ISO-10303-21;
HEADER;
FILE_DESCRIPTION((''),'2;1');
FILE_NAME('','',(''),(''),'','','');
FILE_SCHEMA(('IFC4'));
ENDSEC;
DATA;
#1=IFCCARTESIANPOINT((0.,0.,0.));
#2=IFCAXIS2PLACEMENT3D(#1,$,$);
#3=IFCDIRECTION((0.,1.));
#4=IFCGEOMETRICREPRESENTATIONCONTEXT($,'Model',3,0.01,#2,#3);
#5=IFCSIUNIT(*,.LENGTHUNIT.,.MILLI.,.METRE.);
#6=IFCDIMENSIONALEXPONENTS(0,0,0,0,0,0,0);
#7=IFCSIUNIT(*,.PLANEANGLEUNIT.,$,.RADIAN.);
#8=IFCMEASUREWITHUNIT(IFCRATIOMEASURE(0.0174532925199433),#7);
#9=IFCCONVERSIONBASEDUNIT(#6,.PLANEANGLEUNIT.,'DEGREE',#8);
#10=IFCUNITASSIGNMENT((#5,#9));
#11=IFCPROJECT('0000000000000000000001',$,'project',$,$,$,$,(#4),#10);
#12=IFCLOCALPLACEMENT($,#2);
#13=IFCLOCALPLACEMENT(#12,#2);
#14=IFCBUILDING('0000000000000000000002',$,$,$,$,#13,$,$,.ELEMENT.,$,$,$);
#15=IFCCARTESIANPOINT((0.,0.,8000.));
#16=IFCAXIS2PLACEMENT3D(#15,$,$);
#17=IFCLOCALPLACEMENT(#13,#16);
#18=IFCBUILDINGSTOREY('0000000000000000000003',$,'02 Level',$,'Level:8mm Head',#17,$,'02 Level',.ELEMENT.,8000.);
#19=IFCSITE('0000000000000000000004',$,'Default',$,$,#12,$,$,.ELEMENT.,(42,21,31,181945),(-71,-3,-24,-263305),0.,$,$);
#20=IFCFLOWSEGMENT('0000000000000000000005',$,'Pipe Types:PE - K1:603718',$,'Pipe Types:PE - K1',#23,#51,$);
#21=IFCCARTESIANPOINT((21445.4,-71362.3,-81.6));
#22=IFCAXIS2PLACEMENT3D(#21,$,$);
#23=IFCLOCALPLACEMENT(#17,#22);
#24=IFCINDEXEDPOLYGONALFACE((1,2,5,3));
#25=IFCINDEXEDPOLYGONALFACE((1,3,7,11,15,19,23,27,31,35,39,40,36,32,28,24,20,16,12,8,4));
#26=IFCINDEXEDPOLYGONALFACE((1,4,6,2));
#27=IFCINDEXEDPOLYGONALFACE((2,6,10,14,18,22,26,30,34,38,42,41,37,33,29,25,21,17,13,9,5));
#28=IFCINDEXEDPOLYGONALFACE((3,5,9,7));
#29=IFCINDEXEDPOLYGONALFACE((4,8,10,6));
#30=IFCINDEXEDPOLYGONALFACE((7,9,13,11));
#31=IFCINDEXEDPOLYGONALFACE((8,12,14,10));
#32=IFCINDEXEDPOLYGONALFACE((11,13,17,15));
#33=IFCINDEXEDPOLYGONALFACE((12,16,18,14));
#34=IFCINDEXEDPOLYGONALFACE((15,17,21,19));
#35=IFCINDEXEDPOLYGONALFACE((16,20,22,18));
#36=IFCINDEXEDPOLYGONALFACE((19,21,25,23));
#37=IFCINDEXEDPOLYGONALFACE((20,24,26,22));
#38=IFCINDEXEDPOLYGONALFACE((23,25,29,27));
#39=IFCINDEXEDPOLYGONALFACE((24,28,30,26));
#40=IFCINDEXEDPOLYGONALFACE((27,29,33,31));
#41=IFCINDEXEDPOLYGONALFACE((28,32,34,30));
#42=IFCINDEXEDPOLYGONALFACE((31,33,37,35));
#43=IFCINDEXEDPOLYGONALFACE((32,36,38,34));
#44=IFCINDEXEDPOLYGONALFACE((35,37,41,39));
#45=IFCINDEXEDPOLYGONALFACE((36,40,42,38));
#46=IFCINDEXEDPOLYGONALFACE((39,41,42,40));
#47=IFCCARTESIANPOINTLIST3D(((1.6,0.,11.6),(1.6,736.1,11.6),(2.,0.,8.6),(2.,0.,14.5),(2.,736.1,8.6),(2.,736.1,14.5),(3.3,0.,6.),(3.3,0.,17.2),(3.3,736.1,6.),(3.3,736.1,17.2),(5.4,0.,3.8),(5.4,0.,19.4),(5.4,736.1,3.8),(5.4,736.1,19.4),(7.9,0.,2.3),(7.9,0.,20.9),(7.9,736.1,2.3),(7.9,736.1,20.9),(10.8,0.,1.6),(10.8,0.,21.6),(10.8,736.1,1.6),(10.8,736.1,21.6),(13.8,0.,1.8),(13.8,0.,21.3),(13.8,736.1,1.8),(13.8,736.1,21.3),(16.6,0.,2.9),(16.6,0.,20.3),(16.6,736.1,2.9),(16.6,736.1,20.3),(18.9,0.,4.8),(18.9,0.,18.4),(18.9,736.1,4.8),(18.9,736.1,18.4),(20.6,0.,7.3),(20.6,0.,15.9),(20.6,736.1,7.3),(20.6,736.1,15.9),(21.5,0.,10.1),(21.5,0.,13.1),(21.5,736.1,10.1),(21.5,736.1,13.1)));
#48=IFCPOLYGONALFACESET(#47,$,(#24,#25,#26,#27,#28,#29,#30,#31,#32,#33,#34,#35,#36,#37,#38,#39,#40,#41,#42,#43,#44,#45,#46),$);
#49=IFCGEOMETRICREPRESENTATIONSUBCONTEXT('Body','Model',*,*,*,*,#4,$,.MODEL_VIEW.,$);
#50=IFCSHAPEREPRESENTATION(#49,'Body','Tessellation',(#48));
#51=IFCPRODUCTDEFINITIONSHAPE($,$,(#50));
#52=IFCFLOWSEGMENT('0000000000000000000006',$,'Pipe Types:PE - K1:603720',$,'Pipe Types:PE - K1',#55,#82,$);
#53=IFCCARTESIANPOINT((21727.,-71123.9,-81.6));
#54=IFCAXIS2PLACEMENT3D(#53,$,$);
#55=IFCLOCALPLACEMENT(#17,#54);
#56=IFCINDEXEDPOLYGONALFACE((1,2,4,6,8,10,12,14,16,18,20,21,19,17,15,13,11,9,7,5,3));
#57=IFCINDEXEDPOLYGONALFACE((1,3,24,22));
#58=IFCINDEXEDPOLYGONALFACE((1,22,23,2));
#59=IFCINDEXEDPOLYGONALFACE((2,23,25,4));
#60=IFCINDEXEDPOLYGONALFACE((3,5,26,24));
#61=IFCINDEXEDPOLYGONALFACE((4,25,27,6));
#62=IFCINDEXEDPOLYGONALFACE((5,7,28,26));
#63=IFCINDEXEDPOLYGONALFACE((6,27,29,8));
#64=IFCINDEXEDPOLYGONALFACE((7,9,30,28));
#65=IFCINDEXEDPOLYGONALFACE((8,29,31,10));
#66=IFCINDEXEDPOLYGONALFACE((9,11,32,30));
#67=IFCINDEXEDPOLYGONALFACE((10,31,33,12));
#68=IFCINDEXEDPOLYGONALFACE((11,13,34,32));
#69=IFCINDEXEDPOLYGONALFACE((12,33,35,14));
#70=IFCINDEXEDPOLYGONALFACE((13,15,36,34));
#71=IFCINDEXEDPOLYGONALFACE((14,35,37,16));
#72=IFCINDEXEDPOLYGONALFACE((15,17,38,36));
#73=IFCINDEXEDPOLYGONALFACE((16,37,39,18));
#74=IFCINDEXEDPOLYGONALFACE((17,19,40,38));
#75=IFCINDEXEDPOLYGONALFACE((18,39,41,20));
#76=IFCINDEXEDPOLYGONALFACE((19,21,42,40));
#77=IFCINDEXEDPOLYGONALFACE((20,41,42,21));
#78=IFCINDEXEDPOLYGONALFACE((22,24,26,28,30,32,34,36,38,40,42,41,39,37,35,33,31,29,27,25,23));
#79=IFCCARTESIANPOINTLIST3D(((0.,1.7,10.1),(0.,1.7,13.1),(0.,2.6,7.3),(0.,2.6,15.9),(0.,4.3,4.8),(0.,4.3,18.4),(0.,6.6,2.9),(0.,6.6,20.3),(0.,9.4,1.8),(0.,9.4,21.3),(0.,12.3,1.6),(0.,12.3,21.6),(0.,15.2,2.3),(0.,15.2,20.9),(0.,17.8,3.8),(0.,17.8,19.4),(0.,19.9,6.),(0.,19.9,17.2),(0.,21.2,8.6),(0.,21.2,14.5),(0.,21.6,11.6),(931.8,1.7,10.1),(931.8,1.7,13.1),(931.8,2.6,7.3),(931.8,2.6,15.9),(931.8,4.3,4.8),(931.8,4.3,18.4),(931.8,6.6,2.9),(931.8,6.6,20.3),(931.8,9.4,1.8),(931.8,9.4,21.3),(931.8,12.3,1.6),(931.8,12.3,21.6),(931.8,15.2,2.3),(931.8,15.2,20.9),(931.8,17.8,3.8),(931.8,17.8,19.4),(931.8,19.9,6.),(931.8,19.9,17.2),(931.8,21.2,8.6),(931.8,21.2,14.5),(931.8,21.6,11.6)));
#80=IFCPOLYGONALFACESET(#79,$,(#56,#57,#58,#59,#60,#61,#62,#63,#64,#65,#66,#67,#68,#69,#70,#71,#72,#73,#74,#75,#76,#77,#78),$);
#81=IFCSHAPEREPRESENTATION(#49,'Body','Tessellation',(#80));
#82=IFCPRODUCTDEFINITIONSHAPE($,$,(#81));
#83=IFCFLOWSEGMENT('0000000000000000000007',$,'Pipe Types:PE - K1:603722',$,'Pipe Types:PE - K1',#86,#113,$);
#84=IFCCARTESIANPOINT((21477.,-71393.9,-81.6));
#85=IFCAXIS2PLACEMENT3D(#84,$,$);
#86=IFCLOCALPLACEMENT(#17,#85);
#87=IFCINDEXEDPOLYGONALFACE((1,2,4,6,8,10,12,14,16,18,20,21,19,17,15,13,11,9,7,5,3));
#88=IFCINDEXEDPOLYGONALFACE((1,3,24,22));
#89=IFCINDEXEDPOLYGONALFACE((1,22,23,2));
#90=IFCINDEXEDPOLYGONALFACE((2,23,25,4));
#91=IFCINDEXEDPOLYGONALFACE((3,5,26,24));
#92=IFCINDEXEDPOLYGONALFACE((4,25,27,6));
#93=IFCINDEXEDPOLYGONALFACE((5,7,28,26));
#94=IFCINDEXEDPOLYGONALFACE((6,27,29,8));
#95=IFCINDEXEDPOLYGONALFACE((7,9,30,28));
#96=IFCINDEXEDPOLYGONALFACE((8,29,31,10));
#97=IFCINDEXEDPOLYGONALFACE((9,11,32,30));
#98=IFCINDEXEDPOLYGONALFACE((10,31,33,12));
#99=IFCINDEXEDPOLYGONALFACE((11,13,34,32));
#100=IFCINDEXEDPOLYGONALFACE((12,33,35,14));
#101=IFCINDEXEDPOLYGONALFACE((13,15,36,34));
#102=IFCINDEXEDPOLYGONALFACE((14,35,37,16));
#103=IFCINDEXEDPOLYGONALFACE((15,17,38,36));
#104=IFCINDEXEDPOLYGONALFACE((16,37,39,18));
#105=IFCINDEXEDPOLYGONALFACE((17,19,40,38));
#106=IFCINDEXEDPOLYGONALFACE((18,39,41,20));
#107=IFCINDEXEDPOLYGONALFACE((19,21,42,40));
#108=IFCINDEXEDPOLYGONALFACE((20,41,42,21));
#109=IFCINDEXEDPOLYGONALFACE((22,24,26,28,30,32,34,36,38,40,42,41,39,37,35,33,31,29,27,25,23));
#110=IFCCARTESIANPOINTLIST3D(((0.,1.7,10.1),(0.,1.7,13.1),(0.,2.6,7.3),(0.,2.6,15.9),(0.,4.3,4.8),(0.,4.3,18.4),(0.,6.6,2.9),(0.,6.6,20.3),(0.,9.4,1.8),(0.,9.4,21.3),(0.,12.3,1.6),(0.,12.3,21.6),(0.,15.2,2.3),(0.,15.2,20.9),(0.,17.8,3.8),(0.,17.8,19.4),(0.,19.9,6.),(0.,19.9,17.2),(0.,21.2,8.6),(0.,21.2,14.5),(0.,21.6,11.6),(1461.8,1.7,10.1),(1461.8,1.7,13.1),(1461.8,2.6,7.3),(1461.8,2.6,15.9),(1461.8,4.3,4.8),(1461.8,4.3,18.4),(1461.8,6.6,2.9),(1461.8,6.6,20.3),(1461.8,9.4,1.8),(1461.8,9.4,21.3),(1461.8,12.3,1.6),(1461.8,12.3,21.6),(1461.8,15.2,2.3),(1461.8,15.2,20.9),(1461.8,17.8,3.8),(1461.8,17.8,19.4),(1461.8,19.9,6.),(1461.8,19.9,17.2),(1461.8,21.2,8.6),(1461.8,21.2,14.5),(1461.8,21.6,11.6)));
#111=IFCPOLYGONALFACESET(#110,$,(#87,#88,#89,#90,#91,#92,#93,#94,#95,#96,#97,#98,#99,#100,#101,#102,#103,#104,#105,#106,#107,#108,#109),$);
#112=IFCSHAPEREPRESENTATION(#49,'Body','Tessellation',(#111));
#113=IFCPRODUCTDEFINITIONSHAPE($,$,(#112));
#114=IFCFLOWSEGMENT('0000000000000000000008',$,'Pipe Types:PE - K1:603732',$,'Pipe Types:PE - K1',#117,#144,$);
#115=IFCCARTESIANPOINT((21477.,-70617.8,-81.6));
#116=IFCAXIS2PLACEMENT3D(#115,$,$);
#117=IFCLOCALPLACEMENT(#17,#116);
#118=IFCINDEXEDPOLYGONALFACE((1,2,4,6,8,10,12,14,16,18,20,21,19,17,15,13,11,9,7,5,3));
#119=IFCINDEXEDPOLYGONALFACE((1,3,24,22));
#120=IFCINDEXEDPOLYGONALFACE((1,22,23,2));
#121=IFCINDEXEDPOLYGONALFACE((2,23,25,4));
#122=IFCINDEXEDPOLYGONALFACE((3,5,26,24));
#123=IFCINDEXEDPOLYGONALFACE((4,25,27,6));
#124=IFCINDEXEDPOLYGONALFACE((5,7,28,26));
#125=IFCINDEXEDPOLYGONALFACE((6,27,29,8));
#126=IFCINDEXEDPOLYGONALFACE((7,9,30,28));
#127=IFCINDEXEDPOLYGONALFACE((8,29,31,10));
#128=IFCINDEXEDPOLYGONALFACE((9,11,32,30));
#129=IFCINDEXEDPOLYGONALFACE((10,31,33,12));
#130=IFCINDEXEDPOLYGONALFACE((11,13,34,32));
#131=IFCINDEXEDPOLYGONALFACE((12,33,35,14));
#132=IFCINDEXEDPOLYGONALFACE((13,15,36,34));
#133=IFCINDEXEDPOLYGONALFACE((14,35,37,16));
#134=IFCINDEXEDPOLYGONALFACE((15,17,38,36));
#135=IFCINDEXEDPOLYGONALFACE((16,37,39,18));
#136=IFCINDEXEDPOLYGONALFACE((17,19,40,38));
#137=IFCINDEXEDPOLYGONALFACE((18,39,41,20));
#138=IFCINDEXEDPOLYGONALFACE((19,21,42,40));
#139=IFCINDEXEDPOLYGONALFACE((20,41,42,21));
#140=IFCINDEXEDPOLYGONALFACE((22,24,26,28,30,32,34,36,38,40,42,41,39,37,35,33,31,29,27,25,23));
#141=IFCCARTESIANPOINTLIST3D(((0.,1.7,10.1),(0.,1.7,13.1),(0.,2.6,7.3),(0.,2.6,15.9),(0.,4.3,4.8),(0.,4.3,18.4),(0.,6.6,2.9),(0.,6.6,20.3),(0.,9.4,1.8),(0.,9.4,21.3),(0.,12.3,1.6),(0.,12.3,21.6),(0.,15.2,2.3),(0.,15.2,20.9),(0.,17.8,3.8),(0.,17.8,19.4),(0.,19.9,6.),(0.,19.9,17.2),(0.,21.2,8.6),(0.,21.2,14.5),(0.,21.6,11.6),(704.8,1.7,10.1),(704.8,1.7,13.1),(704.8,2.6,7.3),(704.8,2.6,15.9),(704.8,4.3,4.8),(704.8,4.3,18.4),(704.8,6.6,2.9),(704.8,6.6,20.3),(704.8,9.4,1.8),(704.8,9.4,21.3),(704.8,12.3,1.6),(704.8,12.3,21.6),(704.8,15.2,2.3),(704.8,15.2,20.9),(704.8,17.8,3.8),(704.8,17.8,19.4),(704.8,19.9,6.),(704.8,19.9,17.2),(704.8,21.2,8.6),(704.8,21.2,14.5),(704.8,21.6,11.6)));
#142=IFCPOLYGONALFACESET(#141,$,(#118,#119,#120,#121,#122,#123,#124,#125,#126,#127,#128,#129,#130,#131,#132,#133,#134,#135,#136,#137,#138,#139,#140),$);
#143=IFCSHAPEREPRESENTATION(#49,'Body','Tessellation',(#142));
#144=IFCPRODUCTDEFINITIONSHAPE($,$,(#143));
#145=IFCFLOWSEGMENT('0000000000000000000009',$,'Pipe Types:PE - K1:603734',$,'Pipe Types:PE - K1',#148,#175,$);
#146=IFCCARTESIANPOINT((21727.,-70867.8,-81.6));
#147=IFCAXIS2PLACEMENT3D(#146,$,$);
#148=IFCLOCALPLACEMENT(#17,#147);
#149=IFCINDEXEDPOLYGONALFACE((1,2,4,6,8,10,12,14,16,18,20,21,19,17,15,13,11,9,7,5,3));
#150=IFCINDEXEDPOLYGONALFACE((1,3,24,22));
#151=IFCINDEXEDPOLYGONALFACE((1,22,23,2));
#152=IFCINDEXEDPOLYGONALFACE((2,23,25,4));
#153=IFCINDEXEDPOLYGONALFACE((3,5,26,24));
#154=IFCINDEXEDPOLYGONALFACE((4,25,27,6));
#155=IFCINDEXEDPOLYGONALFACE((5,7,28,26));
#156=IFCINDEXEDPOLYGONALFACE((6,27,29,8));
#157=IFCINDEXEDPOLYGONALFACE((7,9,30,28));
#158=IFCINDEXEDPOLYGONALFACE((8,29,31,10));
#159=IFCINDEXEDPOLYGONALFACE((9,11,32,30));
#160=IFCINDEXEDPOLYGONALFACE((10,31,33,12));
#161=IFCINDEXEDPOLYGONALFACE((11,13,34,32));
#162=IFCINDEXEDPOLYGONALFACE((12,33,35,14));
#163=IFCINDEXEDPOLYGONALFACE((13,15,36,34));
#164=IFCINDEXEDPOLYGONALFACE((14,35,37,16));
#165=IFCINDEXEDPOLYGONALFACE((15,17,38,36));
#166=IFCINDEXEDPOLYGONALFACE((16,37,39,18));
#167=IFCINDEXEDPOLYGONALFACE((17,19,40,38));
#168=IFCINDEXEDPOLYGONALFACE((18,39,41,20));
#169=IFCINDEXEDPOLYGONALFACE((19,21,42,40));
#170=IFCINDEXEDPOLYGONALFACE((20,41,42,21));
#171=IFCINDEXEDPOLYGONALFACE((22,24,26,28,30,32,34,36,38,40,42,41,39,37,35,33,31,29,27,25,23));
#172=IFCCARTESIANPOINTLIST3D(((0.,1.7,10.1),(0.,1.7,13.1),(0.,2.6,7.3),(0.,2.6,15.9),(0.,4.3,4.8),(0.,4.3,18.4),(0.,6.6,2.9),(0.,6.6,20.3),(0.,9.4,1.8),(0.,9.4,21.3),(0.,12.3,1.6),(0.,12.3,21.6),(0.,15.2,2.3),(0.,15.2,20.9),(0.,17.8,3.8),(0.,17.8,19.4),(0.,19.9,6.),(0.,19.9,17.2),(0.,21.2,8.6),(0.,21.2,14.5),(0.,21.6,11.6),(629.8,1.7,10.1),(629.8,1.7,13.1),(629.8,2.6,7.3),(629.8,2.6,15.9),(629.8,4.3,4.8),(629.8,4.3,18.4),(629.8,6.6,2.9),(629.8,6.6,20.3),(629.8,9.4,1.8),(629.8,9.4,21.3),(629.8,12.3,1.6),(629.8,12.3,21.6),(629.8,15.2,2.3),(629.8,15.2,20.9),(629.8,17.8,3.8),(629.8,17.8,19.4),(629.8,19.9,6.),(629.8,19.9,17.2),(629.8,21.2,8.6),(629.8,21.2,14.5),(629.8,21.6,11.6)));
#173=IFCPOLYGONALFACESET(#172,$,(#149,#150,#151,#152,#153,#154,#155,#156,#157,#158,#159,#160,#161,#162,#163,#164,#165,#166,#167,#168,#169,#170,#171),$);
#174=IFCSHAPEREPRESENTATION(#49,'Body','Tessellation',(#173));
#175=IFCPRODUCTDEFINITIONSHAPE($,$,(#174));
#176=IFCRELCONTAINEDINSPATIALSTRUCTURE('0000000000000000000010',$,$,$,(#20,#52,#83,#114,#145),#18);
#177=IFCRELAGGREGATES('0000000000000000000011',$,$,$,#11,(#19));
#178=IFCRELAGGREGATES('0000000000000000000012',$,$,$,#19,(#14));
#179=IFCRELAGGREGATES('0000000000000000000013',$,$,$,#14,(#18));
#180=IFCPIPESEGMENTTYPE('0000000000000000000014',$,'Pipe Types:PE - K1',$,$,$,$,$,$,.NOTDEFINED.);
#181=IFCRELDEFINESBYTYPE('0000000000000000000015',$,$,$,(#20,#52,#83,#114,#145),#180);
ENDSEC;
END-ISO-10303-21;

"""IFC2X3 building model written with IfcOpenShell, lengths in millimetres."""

from ifc_helpers import new_model, entity, si_unit, converted_unit, direction, frame, frame_2d, origin, origin_2d_with_axis, place, context, subcontext, project, spatial, circle, extrude, type_object, element, save


model = new_model("IFC2X3")

# Units and contexts
model_context = context("Model", 3, precision=0.01, world=origin(), true_north=direction((0.0, 1.0)))
body_context = subcontext(model_context, "Body", "Model", "MODEL_VIEW")
ifc_project = project(units=[si_unit("LENGTHUNIT", "METRE", prefix="MILLI"), converted_unit("PLANEANGLEUNIT", "DEGREE", entity("IfcRatioMeasure", 0.0174532925199433), si_unit("PLANEANGLEUNIT", "RADIAN"), dimensions=[0, 0, 0, 0, 0, 0, 0])], contexts=[model_context])

# Site, building, storey
site_placement = place(None, origin())
site = spatial("IfcSite", under=ifc_project, at=site_placement, Name="Default", CompositionType="ELEMENT", RefLatitude=(42, 21, 31, 181945), RefLongitude=(-71, -3, -24, -263305), RefElevation=0.0)
building_placement = place(site_placement, origin())
building = spatial("IfcBuilding", under=site, at=building_placement, CompositionType="ELEMENT")
storey_placement = place(building_placement, frame((0.0, 0.0, 8000.0)))
storey = spatial("IfcBuildingStorey", under=building, at=storey_placement, Name="02 Level", ObjectType="Level:8mm Head", LongName="02 Level", CompositionType="ELEMENT", Elevation=8000.0)

# Flow segments
pipe_segment_type = type_object("IfcPipeSegmentType", Name="Pipe Types:PE - K1", PredefinedType="NOTDEFINED")
flow_segment_1_placement = place(storey_placement, frame((21445.4, -71362.3, -81.6)))
element("IfcFlowSegment", 1, at=flow_segment_1_placement, inside=storey, type_object=pipe_segment_type, Name="Pipe Types:PE - K1:603718", ObjectType="Pipe Types:PE - K1", context=body_context, shape_type="SweptSolid", body=[
    extrude(circle(Radius=10.0, at=frame_2d((0.0, 0.0), x_axis=(1.0, 0.0))), frame((11.6, 0.0, 11.6), z_axis=(0.0, 1.0, 0.0), x_axis=(-1.0, 0.0, 0.0)), (0.0, 0.0, 1.0), 736.1),
])
flow_segment_2_placement = place(storey_placement, frame((21727.0, -71123.9, -81.6)))
element("IfcFlowSegment", 2, at=flow_segment_2_placement, inside=storey, type_object=pipe_segment_type, Name="Pipe Types:PE - K1:603720", ObjectType="Pipe Types:PE - K1", context=body_context, shape_type="SweptSolid", body=[
    extrude(circle(Radius=10.0, at=frame_2d((0.0, 0.0), x_axis=(1.0, 0.0))), frame((0.0, 11.6, 11.6), z_axis=(1.0, 0.0, 0.0), x_axis=(0.0, 1.0, 0.0)), (0.0, 0.0, 1.0), 931.8),
])
flow_segment_3_placement = place(storey_placement, frame((21477.0, -71393.9, -81.6)))
element("IfcFlowSegment", 3, at=flow_segment_3_placement, inside=storey, type_object=pipe_segment_type, Name="Pipe Types:PE - K1:603722", ObjectType="Pipe Types:PE - K1", context=body_context, shape_type="SweptSolid", body=[
    extrude(circle(Radius=10.0, at=origin_2d_with_axis()), frame((0.0, 11.6, 11.6), z_axis=(1.0, 0.0, 0.0), x_axis=(0.0, 1.0, 0.0)), (0.0, 0.0, 1.0), 1461.8),
])
flow_segment_4_placement = place(storey_placement, frame((21477.0, -70617.8, -81.6)))
element("IfcFlowSegment", 4, at=flow_segment_4_placement, inside=storey, type_object=pipe_segment_type, Name="Pipe Types:PE - K1:603732", ObjectType="Pipe Types:PE - K1", context=body_context, shape_type="SweptSolid", body=[
    extrude(circle(Radius=10.0, at=frame_2d((0.0, 0.0), x_axis=(1.0, 0.0))), frame((0.0, 11.6, 11.6), z_axis=(1.0, 0.0, 0.0), x_axis=(0.0, 1.0, 0.0)), (0.0, 0.0, 1.0), 704.8),
])
flow_segment_5_placement = place(storey_placement, frame((21727.0, -70867.8, -81.6)))
element("IfcFlowSegment", 5, at=flow_segment_5_placement, inside=storey, type_object=pipe_segment_type, Name="Pipe Types:PE - K1:603734", ObjectType="Pipe Types:PE - K1", context=body_context, shape_type="SweptSolid", body=[
    extrude(circle(Radius=10.0, at=frame_2d((0.0, 0.0), x_axis=(1.0, 0.0))), frame((0.0, 11.6, 11.6), z_axis=(1.0, 0.0, 0.0), x_axis=(0.0, 1.0, 0.0)), (0.0, 0.0, 1.0), 629.8),
])

save(model, "model.ifc")
